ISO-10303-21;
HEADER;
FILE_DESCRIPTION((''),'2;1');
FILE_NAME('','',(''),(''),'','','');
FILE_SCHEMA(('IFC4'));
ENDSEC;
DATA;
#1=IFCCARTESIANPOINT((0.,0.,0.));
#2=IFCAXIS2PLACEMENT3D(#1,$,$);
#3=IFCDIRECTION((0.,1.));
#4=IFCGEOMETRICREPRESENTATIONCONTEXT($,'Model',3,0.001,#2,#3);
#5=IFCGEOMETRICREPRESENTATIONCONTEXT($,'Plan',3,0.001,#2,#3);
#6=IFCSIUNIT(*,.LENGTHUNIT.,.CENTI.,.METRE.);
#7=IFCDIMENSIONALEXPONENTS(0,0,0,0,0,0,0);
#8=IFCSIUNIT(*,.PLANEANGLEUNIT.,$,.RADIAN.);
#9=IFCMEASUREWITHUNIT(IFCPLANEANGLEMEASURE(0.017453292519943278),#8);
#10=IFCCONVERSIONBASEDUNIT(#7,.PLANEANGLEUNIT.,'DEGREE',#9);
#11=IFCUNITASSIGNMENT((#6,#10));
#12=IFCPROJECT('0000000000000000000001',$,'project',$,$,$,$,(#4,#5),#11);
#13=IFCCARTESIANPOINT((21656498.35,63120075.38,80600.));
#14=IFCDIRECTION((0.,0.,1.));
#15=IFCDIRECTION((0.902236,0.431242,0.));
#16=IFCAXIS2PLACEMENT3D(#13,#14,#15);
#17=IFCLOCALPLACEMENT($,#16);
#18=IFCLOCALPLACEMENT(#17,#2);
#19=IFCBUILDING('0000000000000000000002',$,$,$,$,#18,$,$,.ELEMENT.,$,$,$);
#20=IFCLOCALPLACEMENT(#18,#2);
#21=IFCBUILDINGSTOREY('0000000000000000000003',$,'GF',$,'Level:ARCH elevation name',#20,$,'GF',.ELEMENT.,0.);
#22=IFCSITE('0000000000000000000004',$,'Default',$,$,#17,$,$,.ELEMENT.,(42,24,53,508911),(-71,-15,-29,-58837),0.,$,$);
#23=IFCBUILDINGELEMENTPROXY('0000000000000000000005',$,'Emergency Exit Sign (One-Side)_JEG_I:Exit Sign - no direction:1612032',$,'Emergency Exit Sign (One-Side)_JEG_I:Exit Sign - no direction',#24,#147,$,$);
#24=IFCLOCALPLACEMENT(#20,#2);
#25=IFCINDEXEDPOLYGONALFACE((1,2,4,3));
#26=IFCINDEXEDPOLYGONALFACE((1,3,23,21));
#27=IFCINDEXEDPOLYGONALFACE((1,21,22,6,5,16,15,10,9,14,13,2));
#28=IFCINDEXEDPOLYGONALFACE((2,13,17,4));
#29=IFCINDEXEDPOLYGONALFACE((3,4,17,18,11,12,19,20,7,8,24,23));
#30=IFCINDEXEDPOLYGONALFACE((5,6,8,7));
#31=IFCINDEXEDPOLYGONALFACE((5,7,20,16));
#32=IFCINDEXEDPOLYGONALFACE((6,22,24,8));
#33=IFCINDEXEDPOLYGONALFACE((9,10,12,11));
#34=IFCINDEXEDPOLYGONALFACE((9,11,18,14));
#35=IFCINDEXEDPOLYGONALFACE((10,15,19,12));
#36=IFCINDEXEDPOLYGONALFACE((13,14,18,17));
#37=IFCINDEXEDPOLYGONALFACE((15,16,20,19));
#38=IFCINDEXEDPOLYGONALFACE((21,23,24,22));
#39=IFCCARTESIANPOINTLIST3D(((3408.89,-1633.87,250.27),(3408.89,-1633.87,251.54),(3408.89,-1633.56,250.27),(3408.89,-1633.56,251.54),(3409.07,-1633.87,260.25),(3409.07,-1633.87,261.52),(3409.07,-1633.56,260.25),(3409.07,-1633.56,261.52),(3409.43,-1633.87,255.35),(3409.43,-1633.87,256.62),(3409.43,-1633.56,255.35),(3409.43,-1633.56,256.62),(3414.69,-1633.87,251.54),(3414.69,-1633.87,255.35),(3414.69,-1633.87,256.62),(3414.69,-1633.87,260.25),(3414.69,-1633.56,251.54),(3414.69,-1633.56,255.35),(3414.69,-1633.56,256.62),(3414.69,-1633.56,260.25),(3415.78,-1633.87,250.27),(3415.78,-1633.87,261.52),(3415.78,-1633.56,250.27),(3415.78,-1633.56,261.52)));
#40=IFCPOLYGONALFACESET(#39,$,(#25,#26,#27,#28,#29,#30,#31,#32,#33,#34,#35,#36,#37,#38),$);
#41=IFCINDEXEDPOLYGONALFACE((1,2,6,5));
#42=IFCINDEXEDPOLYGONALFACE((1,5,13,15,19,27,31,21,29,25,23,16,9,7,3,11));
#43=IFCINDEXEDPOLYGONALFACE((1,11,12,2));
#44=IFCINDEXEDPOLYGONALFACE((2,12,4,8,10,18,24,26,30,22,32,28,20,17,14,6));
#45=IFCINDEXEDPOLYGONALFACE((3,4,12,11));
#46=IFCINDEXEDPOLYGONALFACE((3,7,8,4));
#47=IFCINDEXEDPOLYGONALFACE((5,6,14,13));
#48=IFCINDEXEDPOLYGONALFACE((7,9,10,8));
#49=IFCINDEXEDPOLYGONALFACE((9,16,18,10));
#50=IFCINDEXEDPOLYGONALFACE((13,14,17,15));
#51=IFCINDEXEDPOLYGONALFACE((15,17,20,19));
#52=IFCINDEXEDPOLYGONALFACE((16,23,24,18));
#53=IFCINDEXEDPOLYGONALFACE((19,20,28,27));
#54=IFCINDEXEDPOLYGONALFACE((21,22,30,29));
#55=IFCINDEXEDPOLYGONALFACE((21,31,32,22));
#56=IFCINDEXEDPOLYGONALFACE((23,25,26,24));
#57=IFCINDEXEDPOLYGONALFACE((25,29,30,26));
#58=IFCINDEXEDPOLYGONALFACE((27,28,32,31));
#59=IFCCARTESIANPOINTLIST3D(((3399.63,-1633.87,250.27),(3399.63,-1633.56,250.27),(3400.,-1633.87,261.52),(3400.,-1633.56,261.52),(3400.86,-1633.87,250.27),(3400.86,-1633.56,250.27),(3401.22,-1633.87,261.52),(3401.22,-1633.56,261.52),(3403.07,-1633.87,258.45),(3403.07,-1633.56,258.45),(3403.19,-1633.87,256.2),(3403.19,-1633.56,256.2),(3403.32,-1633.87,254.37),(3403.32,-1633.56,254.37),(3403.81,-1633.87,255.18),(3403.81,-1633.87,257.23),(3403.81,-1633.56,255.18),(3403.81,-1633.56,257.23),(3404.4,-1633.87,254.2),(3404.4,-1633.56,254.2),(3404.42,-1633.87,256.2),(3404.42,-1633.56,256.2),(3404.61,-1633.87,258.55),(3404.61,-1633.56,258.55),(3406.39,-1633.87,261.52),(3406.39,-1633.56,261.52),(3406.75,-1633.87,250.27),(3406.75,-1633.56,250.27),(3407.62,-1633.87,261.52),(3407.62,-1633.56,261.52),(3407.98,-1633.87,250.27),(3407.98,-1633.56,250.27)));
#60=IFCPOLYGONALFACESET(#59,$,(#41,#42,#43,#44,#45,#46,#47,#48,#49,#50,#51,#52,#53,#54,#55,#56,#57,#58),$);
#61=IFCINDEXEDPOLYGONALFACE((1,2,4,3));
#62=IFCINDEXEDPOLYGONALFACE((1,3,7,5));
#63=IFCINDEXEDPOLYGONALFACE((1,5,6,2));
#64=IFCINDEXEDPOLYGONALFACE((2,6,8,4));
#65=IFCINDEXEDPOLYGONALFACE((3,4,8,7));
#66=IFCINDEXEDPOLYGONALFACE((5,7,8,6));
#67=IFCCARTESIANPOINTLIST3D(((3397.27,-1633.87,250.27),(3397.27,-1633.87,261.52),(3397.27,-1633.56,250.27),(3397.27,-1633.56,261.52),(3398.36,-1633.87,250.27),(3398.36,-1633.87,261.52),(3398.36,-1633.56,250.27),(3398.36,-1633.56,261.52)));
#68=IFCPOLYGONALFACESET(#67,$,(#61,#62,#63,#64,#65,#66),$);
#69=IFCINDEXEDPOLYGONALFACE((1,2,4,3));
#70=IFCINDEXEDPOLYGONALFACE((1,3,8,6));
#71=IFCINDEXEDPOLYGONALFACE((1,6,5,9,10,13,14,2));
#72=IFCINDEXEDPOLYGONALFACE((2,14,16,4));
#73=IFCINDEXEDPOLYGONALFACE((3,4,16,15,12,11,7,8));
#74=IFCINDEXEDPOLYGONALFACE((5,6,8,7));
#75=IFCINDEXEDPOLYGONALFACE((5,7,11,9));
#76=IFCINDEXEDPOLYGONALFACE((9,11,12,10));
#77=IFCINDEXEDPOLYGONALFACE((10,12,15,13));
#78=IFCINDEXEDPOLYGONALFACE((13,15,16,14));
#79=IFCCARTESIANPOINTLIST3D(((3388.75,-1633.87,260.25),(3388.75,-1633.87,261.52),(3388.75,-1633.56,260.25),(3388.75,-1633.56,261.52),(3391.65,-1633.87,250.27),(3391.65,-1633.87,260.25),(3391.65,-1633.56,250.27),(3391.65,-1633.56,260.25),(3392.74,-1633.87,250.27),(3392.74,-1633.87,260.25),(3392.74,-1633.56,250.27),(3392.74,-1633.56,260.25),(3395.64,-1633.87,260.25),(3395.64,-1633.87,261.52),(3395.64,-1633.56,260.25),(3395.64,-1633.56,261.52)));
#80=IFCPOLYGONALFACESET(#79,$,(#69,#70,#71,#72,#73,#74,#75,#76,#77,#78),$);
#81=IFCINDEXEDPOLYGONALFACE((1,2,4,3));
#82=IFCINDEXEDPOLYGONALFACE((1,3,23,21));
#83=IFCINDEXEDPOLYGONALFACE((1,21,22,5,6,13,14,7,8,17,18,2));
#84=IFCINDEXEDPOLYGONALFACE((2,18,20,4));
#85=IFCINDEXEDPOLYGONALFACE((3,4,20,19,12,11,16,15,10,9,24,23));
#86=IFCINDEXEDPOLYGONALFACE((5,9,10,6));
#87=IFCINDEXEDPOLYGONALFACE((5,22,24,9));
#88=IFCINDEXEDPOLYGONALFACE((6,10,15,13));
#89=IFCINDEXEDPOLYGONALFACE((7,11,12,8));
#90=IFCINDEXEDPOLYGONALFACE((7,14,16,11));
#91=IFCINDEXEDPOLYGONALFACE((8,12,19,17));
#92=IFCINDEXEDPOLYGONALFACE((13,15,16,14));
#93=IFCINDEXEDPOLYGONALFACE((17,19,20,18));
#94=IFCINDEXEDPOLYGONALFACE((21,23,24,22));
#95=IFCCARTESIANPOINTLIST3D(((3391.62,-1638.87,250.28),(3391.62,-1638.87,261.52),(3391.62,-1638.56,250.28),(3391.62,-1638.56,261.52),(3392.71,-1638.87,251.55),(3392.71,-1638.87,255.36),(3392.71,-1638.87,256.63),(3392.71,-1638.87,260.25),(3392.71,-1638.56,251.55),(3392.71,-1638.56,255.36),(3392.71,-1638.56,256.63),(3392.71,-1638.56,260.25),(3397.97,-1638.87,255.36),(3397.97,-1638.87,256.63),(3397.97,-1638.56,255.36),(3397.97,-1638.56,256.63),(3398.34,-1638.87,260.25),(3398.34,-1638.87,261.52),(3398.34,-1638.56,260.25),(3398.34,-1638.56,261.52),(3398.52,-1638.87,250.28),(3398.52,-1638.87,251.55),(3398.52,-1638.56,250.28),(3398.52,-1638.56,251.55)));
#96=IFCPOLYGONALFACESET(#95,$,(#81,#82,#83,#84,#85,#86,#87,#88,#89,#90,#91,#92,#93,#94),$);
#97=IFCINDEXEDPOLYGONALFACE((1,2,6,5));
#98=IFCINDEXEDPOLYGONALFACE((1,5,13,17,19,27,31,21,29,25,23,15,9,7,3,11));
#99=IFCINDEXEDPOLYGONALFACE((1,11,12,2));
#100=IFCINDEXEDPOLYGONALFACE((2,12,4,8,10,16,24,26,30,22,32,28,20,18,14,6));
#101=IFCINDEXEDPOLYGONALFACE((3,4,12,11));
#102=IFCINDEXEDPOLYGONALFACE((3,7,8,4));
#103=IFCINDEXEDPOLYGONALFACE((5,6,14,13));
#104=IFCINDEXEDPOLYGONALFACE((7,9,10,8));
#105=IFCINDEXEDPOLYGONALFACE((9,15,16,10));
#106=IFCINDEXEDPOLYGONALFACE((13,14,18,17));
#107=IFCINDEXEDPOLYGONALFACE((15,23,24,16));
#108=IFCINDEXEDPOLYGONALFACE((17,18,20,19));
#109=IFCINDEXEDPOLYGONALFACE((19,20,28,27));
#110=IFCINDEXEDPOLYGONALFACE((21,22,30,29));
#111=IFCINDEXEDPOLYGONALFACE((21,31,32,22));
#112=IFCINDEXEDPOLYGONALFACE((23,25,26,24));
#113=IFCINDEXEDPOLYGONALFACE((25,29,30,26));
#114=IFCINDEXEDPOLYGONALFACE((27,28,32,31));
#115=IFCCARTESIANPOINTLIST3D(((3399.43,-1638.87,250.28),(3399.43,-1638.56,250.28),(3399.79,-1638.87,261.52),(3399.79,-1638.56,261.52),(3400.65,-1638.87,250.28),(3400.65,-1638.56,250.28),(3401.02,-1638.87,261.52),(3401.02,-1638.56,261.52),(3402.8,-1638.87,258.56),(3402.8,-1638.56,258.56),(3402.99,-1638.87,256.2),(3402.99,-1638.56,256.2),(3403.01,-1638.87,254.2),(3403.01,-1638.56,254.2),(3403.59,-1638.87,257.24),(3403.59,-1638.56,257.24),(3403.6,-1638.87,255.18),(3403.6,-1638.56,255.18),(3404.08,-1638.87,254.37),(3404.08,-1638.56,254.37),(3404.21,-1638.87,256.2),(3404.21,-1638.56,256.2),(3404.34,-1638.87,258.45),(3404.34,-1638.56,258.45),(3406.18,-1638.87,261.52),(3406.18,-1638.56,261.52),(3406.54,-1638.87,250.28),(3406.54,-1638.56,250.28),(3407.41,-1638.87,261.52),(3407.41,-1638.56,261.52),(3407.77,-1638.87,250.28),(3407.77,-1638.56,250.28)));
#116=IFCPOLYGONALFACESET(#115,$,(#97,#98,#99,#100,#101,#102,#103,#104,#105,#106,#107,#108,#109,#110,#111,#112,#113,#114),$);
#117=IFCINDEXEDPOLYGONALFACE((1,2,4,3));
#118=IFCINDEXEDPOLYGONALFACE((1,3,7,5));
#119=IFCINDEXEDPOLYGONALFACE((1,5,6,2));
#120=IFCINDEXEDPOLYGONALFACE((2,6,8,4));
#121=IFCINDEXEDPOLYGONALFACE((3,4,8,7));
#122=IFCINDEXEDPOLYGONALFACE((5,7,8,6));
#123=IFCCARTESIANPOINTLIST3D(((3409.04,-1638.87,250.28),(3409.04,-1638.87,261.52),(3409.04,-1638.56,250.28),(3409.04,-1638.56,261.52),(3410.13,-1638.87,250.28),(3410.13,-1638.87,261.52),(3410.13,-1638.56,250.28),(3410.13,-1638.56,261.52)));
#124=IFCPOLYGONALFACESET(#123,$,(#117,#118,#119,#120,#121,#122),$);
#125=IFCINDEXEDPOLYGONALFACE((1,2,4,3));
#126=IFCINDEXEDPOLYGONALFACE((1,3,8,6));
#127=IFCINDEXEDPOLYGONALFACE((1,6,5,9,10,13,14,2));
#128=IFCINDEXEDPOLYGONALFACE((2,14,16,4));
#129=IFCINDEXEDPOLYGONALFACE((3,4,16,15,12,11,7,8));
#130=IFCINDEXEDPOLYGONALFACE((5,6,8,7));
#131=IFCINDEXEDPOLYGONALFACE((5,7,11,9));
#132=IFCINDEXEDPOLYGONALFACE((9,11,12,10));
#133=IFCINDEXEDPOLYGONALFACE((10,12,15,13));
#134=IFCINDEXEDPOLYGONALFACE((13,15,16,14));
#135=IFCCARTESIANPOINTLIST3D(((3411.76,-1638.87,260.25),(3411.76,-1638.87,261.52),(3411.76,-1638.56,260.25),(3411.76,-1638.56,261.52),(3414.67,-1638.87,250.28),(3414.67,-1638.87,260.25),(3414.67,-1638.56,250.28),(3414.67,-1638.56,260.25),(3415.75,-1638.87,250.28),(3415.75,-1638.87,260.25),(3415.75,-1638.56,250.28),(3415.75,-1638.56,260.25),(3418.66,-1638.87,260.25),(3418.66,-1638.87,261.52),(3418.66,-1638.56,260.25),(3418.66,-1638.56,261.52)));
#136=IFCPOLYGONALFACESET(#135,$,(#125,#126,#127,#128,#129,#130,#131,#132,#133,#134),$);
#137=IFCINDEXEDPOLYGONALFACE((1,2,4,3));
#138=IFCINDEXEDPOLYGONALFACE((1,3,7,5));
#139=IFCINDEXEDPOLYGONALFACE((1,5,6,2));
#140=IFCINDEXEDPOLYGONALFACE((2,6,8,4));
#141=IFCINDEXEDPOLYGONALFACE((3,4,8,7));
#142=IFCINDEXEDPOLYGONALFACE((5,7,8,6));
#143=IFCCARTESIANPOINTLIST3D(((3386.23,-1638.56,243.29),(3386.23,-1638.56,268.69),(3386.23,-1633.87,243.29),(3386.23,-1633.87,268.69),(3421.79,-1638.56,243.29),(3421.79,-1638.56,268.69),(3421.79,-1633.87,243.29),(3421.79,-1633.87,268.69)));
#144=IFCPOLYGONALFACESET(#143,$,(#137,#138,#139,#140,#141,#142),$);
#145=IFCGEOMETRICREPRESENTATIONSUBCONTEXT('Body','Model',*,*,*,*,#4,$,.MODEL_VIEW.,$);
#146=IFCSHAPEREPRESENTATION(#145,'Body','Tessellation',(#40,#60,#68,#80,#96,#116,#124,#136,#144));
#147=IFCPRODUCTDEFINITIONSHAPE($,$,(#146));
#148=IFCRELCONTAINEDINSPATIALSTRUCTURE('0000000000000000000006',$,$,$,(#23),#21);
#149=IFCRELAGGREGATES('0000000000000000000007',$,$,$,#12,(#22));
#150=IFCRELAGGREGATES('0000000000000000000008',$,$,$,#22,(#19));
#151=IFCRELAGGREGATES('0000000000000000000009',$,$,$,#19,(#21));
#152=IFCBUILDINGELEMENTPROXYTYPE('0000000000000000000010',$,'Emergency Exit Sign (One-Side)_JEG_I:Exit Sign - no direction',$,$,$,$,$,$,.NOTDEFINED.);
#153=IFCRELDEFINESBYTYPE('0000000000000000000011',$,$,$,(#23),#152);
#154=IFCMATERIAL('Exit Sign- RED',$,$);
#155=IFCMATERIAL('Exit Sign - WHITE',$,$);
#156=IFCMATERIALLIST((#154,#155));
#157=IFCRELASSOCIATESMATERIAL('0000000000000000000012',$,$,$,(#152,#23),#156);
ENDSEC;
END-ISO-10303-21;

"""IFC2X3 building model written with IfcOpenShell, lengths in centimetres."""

from ifc_helpers import new_model, entity, si_unit, converted_unit, direction, frame, frame_2d, origin, origin_2d_with_axis, place, context, subcontext, project, spatial, polyline, rectangle, outline, extrude, source, transform, mapped, material, material_list, type_object, type_shapes, element, save


model = new_model("IFC2X3")

# Units and contexts
model_context = context("Model", 3, precision=0.001, world=origin(), true_north=direction((0.0, 1.0)))
plan_context = context("Plan", 3, precision=0.001, world=origin(), true_north=direction((0.0, 1.0)))
body_context = subcontext(model_context, "Body", "Model", "MODEL_VIEW")
ifc_project = project(units=[si_unit("LENGTHUNIT", "METRE", prefix="CENTI"), converted_unit("PLANEANGLEUNIT", "DEGREE", entity("IfcPlaneAngleMeasure", 0.017453292519943278), si_unit("PLANEANGLEUNIT", "RADIAN"), dimensions=[0, 0, 0, 0, 0, 0, 0])], contexts=[model_context, plan_context])

# Site, building, storey
site_placement = place(None, frame((21656498.35, 63120075.38, 80600.0), z_axis=(0.0, 0.0, 1.0), x_axis=(0.902236, 0.431242, 0.0)))
site = spatial("IfcSite", under=ifc_project, at=site_placement, Name="Default", CompositionType="ELEMENT", RefLatitude=(42, 24, 53, 508911), RefLongitude=(-71, -15, -29, -58837), RefElevation=0.0)
building_placement = place(site_placement, origin())
building = spatial("IfcBuilding", under=site, at=building_placement, CompositionType="ELEMENT")
storey_placement = place(building_placement, origin())
storey = spatial("IfcBuildingStorey", under=building, at=storey_placement, Name="GF", ObjectType="Level:ARCH elevation name", LongName="GF", CompositionType="ELEMENT", Elevation=0.0)

# Building element proxy
ifc_material_1 = material(Name="Exit Sign- RED")
ifc_material_2 = material(Name="Exit Sign - WHITE")
ifc_material_list_1 = material_list([ifc_material_1, ifc_material_2])
building_element_proxy_type_1 = type_object("IfcBuildingElementProxyType", Name="Emergency Exit Sign (One-Side)_JEG_I:Exit Sign - no direction", PredefinedType="NOTDEFINED", material=ifc_material_list_1)
shared_shape_1 = source(origin(), body_context, "Body", "SweptSolid", [
    extrude(outline(polyline([(-5.65, -3.69), (5.59, -3.69), (5.59, 3.02), (4.32, 3.02), (4.32, -2.6), (0.7, -2.6), (0.7, 2.66), (-0.57, 2.66), (-0.57, -2.6), (-4.38, -2.6), (-4.38, 3.21), (-5.65, 3.21), (-5.65, -3.69)])), frame((-8.08, -5.22, 12.64), z_axis=(0.0, 1.0, 0.0), x_axis=(0.0, 0.0, 1.0)), (0.0, 0.0, 1.0), 0.32),
    extrude(outline(polyline([(-7.14, 0.57), (-6.5, -0.49), (-1.93, -0.48), (-0.78, -0.48), (-1.23, -1.32), (-3.47, -5.53), (-2.84, -6.59), (0.41, -0.48), (6.62, -0.48), (5.99, 0.57), (2.4, 0.57), (0.98, 0.58), (1.7, 1.94), (3.32, 5.0), (2.69, 6.05), (-0.22, 0.57), (-7.14, 0.57)])), frame((0.2, -5.22, 12.81), z_axis=(0.0, -1.0, 0.0), x_axis=(0.515099, 0.0, 0.857131)), (0.0, 0.0, -1.0), 0.32),
    extrude(rectangle(XDim=0.32, YDim=1.09, at=frame_2d((0.0, 0.0), x_axis=(1.0, 0.0))), frame((6.19, -5.06, 6.99), z_axis=(0.0, 0.0, 1.0), x_axis=(0.0, 1.0, 0.0)), (0.0, 0.0, 1.0), 11.25),
    extrude(outline(polyline([(-7.8, 0.54), (-7.8, -0.54), (2.18, -0.54), (2.18, -3.45), (3.45, -3.45), (3.45, 3.45), (2.18, 3.45), (2.18, 0.54), (-7.8, 0.54)])), frame((11.82, -5.22, 14.79), z_axis=(0.0, -1.0, 0.0), x_axis=(0.0, 0.0, 1.0)), (0.0, 0.0, -1.0), 0.32),
    extrude(outline(polyline([(-3.69, -5.65), (3.21, -5.65), (3.21, -4.38), (-2.6, -4.38), (-2.6, -0.57), (2.66, -0.57), (2.66, 0.7), (-2.6, 0.7), (-2.6, 4.32), (3.02, 4.32), (3.02, 5.59), (-3.69, 5.59), (-3.69, -5.65)])), frame((8.7, -0.22, 12.65), z_axis=(0.0, 1.0, 0.0), x_axis=(-1.0, 0.0, 0.0)), (0.0, 0.0, 1.0), 0.32),
    extrude(outline(polyline([(-4.16, -5.82), (-2.93, -5.82), (-0.58, -1.9), (0.01, -0.92), (0.5, -1.73), (2.96, -5.82), (4.18, -5.82), (0.62, 0.1), (3.82, 5.42), (2.59, 5.42), (0.75, 2.35), (0.01, 1.14), (-0.79, 2.46), (-2.57, 5.42), (-3.8, 5.42), (-0.6, 0.1), (-4.16, -5.82)])), frame((0.43, -0.22, 12.82), z_axis=(0.0, 1.0, 0.0), x_axis=(-1.0, 0.0, 0.0)), (0.0, 0.0, 1.0), 0.32),
    extrude(rectangle(XDim=0.32, YDim=1.09, at=origin_2d_with_axis()), frame((-5.57, -0.06, 6.99), z_axis=(0.0, 0.0, 1.0), x_axis=(0.0, -1.0, 0.0)), (0.0, 0.0, 1.0), 11.25),
    extrude(outline(polyline([(-0.54, -7.8), (0.54, -7.8), (0.54, 2.18), (3.45, 2.18), (3.45, 3.45), (-3.45, 3.45), (-3.45, 2.18), (-0.54, 2.18), (-0.54, -7.8)])), frame((-11.2, -0.22, 14.79), z_axis=(0.0, 1.0, 0.0), x_axis=(-1.0, 0.0, 0.0)), (0.0, 0.0, 1.0), 0.32),
    extrude(rectangle(XDim=4.68, YDim=35.56, at=origin_2d_with_axis()), frame((0.0, -2.56, 0.01), z_axis=(0.0, 0.0, 1.0), x_axis=(0.0, 1.0, 0.0)), (0.0, 0.0, 1.0), 25.4),
])
type_shapes(building_element_proxy_type_1, [shared_shape_1])
for number, where, z_axis, x_axis, name in (
    (1, (3404.01, -1638.78, 243.28), (0.0, 0.0, 1.0), (-1.0, 0.0, 0.0), "Emergency Exit Sign (One-Side)_JEG_I:Exit Sign - no direction:1612032"),
):
    element("IfcBuildingElementProxy", number, at=place(storey_placement, frame(where, z_axis=z_axis, x_axis=x_axis)), inside=storey, type_object=building_element_proxy_type_1, material=ifc_material_list_1, Name=name, ObjectType="Emergency Exit Sign (One-Side)_JEG_I:Exit Sign - no direction", context=body_context, shape_type="MappedRepresentation", body=[
        mapped(shared_shape_1, transform((0.0, 0.0, 0.0), scale=1.0)),
    ])

save(model, "model.ifc")
